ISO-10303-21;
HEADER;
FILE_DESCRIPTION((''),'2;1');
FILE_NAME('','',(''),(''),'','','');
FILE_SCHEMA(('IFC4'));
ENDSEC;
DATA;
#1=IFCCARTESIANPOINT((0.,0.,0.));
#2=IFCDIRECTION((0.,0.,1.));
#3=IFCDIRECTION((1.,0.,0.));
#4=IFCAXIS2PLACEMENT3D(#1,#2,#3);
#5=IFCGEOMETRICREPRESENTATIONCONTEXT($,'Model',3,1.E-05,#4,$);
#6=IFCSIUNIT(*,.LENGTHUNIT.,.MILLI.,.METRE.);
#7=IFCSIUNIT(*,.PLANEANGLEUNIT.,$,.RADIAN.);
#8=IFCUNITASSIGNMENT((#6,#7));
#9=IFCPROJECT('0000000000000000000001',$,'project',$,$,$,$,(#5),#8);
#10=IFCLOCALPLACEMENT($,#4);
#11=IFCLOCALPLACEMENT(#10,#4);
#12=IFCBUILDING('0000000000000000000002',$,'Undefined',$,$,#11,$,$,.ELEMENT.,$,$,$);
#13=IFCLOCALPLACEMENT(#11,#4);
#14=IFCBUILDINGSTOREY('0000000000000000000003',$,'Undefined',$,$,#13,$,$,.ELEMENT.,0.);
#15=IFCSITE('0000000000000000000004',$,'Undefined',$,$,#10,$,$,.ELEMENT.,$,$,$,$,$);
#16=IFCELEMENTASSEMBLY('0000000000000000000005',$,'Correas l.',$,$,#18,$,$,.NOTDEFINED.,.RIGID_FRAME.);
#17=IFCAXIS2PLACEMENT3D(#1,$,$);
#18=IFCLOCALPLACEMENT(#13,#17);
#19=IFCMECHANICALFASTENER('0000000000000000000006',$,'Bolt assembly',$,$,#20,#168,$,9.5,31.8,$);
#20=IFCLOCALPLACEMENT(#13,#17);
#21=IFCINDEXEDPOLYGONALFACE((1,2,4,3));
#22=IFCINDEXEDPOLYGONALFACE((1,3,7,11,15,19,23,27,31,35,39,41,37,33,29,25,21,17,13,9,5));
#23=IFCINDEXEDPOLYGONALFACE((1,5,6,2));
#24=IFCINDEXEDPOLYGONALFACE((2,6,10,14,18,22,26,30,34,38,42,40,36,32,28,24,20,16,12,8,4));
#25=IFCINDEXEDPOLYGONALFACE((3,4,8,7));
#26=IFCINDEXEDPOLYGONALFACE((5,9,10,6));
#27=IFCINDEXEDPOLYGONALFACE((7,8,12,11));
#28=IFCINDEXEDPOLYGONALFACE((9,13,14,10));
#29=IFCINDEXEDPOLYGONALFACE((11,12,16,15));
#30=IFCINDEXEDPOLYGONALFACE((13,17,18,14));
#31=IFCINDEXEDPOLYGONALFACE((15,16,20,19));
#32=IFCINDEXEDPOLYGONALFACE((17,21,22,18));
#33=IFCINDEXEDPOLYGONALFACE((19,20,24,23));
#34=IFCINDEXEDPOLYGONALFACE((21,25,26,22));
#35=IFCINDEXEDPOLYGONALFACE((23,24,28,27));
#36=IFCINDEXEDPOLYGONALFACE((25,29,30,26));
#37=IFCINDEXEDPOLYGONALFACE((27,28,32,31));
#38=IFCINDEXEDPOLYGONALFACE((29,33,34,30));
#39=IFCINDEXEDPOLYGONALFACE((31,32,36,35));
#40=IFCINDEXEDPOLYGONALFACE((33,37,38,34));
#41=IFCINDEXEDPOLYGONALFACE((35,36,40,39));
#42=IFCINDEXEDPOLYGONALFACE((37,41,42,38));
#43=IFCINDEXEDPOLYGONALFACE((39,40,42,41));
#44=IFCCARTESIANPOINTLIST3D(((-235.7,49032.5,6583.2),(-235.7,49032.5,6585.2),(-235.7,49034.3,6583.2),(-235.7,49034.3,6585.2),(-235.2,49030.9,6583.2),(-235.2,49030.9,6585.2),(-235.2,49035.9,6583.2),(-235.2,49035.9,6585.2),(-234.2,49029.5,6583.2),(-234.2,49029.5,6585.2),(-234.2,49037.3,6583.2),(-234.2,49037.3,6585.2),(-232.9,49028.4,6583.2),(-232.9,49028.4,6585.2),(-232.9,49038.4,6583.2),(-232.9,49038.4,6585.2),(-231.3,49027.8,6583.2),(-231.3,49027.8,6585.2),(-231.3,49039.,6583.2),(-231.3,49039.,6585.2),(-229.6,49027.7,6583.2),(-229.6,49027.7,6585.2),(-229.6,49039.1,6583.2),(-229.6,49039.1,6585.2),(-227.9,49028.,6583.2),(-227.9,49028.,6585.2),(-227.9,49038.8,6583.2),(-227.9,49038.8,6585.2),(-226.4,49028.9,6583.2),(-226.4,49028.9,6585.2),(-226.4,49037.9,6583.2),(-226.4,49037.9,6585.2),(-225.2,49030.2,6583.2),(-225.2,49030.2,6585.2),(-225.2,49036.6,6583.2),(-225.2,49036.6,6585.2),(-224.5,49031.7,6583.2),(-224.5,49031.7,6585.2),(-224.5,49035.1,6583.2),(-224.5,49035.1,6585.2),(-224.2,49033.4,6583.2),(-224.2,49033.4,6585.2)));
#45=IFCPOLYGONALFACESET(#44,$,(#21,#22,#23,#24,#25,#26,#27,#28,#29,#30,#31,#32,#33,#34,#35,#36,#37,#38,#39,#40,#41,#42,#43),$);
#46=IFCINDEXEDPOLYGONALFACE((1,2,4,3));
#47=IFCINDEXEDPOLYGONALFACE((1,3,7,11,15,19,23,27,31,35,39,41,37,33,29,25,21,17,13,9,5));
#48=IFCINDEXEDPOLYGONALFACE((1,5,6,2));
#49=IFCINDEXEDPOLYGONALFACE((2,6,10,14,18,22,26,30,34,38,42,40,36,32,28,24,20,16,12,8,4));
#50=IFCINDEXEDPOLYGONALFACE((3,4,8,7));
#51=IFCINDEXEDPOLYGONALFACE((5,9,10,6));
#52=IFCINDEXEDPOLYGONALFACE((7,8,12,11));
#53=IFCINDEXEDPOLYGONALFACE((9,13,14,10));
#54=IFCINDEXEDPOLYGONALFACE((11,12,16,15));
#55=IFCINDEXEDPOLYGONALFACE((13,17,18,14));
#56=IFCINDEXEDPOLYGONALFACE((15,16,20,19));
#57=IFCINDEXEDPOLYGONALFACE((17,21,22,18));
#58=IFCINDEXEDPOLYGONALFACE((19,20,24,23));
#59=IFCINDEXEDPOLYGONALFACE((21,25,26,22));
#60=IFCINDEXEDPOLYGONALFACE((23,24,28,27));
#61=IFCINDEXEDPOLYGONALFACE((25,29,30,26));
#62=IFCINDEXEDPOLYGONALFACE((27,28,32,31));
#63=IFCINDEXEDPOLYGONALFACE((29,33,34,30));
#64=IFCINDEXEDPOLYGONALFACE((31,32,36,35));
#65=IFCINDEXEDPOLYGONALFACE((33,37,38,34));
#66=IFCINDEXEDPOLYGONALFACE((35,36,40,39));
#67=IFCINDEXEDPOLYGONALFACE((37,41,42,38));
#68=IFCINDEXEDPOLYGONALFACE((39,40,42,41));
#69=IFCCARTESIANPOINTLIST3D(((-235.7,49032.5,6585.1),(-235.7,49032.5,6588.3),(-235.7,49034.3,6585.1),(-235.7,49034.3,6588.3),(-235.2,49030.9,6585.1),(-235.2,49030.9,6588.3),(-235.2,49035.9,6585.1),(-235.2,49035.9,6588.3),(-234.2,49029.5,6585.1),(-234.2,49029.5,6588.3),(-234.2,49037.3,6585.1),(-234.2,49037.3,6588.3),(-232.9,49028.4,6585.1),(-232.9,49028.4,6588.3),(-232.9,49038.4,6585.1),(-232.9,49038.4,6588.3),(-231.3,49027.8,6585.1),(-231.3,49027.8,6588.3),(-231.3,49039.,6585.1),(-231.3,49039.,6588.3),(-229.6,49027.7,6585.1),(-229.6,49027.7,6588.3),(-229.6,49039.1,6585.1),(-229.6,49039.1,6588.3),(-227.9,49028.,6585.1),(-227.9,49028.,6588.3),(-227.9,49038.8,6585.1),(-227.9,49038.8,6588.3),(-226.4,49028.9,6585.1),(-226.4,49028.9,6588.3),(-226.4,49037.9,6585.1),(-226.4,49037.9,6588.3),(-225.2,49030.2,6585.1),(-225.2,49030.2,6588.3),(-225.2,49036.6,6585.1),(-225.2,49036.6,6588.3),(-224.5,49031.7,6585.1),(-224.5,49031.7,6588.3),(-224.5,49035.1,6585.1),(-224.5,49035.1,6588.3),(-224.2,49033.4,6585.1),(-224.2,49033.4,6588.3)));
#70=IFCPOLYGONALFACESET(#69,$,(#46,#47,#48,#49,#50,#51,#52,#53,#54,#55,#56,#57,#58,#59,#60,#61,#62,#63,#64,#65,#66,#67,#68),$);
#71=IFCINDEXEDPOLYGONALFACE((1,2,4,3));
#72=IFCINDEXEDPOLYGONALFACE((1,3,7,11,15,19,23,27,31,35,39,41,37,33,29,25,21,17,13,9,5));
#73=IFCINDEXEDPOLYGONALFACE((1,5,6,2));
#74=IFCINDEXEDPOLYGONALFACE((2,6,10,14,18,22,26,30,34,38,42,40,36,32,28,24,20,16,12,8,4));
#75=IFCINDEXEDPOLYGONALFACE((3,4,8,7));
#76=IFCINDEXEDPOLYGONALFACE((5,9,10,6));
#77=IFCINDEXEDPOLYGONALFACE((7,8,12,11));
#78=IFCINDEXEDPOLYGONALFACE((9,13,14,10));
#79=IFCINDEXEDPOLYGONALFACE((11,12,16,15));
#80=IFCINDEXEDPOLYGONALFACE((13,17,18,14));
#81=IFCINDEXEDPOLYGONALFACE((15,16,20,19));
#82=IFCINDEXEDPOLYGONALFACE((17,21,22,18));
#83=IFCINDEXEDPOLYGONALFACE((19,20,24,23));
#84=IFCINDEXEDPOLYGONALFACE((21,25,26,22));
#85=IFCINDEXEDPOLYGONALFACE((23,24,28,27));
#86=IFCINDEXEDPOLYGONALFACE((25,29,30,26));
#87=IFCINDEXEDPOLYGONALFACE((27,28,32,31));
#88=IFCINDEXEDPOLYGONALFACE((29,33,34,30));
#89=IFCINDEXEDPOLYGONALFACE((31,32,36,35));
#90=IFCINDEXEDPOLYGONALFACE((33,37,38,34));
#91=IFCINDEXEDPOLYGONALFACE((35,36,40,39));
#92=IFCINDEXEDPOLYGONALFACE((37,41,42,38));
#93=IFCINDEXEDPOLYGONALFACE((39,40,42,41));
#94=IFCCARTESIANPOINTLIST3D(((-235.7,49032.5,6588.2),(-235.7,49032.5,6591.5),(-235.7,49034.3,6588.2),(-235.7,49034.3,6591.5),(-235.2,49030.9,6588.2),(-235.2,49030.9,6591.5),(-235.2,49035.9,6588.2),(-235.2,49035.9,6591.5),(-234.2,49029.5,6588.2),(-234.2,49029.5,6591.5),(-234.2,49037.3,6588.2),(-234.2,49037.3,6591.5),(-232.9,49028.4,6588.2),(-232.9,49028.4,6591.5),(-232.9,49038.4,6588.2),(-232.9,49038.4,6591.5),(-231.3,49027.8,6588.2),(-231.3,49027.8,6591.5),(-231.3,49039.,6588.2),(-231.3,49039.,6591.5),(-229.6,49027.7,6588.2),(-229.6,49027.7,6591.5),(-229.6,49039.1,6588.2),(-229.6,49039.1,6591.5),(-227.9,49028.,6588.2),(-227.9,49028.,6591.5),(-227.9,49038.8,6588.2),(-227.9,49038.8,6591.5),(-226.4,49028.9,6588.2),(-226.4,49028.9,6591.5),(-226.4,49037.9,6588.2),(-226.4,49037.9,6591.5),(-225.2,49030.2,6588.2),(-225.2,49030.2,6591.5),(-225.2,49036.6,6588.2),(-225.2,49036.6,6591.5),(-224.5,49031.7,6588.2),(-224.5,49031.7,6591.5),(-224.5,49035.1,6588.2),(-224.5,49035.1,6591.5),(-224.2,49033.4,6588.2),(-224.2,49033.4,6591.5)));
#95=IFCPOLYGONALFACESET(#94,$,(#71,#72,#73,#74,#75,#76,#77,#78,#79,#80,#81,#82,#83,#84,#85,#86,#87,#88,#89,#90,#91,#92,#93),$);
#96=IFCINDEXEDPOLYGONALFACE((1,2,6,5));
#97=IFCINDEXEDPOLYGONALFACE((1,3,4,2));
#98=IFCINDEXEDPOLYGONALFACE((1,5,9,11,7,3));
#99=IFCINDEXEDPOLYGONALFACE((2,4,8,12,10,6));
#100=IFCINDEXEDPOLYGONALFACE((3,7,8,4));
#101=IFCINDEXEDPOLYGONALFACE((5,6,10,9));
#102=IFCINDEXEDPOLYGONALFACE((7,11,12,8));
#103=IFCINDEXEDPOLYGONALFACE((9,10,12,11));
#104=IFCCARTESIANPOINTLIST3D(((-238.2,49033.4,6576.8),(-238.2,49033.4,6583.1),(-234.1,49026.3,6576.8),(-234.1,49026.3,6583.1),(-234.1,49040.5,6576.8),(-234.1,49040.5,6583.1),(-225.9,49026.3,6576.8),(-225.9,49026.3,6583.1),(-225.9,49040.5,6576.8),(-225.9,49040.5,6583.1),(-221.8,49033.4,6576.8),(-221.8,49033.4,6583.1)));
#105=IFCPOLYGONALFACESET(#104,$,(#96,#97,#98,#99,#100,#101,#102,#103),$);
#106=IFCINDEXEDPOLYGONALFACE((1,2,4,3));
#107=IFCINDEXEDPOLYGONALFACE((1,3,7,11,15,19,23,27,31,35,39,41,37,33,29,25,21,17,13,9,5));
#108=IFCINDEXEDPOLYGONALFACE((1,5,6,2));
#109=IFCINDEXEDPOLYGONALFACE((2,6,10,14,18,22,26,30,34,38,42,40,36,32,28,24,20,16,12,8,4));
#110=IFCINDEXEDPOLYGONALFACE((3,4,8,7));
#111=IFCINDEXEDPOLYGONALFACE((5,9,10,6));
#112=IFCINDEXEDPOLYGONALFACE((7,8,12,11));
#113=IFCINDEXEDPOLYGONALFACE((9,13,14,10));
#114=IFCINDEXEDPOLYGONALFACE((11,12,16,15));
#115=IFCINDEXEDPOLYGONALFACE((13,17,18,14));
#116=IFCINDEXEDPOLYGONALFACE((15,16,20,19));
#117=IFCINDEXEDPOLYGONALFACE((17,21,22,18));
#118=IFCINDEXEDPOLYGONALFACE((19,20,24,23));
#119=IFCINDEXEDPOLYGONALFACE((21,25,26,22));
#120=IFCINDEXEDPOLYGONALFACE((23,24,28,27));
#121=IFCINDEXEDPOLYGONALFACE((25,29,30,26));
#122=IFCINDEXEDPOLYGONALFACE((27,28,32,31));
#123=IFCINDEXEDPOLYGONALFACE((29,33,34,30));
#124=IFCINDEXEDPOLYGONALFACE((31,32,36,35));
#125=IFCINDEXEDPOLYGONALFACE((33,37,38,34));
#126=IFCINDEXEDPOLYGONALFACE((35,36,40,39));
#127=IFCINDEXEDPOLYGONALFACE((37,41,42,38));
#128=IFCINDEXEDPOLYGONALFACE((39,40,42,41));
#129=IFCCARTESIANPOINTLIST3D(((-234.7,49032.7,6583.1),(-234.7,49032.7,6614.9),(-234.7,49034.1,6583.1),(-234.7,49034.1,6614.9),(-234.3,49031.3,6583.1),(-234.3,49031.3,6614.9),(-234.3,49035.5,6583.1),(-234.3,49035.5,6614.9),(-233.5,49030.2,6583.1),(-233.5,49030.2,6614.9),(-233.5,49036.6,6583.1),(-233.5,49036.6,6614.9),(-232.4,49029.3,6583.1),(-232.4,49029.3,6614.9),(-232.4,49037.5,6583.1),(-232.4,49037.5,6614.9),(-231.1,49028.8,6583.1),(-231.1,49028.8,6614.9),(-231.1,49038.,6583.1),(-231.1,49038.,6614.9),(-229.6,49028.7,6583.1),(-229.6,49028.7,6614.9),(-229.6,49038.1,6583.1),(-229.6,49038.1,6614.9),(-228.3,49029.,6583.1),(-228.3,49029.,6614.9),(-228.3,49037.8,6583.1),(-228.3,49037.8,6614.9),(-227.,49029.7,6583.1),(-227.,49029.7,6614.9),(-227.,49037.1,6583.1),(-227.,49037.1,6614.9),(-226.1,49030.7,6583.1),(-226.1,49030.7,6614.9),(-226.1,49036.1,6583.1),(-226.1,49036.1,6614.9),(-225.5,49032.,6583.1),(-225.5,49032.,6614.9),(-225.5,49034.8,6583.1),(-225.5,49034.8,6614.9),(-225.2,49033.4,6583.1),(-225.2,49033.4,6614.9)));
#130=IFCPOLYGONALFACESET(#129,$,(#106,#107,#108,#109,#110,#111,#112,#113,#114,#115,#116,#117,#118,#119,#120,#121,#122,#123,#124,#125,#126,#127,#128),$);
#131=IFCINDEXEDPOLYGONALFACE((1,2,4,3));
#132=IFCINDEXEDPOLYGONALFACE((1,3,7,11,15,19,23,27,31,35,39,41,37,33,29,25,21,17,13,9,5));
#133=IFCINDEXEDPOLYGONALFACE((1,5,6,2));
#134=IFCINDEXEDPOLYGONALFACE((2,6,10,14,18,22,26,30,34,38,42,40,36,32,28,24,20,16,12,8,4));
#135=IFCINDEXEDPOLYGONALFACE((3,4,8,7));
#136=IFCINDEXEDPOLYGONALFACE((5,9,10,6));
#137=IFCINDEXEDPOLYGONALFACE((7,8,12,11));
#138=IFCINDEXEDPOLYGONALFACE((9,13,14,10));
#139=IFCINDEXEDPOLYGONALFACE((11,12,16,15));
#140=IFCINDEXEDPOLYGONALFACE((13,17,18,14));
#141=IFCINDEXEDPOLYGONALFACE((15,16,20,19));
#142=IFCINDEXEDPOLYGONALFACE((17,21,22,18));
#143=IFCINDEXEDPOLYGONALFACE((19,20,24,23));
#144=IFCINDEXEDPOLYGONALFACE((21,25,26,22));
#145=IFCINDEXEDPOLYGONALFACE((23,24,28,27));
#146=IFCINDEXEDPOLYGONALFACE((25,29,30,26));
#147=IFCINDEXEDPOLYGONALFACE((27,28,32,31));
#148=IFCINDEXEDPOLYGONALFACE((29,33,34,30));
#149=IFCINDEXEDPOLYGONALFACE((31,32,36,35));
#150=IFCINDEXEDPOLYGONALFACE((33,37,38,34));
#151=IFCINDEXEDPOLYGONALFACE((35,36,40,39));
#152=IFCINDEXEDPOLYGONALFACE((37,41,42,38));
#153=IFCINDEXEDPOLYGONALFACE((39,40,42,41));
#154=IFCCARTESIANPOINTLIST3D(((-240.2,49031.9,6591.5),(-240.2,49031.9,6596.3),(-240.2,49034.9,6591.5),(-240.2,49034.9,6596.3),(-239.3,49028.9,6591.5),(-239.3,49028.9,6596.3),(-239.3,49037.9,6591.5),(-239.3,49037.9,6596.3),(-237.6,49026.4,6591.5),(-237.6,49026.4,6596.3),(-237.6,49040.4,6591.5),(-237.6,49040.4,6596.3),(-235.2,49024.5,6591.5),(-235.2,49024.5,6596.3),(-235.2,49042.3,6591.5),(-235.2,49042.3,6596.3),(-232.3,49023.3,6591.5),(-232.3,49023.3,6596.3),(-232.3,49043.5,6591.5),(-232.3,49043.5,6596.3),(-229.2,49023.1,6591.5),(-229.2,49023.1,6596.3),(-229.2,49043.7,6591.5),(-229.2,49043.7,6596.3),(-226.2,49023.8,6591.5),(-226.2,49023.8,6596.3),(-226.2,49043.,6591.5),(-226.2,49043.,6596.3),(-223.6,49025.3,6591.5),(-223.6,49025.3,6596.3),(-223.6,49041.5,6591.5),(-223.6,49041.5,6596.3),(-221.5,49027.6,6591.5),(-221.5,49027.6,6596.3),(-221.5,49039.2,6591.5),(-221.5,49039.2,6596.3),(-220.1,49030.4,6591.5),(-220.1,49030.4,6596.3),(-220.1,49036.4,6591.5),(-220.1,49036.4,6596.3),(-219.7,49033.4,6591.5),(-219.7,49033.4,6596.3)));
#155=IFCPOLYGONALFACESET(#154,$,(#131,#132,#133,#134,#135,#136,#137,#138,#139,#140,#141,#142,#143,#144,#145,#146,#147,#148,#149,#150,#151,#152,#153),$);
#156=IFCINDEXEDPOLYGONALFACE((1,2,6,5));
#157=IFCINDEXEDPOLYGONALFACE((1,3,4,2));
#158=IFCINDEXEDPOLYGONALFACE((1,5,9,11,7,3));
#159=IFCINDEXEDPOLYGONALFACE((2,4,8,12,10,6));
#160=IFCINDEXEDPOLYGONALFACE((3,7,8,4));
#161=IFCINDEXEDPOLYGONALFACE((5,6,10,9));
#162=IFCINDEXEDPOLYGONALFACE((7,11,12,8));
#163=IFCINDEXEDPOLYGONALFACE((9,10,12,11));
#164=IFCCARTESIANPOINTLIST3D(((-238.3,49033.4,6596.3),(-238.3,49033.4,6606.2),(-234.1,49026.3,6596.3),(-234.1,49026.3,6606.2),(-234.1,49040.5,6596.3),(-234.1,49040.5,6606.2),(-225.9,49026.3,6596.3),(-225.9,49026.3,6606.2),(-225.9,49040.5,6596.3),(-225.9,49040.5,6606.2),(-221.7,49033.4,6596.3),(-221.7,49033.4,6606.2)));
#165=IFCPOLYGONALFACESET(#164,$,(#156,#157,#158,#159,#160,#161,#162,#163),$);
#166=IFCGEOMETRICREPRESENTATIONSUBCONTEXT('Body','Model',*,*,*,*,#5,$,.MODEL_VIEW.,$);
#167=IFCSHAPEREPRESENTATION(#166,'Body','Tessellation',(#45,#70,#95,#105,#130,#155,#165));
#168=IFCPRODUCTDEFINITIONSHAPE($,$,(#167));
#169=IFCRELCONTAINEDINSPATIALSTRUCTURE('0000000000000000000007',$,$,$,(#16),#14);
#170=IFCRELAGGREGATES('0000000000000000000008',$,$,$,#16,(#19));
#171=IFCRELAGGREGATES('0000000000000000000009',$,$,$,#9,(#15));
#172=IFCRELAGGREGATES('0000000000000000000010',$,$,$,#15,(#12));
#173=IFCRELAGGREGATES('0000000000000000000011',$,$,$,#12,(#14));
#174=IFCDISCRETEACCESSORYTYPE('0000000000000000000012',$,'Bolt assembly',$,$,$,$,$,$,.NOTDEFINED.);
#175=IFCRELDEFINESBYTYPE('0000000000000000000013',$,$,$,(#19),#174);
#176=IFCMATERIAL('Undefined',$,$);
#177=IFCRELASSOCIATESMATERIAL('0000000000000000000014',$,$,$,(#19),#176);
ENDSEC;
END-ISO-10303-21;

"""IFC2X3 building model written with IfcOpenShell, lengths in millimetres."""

from ifc_helpers import new_model, si_unit, frame, origin_with_axes, origin_2d_with_axis, place, context, subcontext, project, spatial, polyline, circle, outline, extrude, source, transform, mapped, material, type_object, element, aggregate, save


model = new_model("IFC2X3")

# Units and contexts
model_context = context("Model", 3, precision=1e-05, world=origin_with_axes())
body_context = subcontext(model_context, "Body", "Model", "MODEL_VIEW")
ifc_project = project(units=[si_unit("LENGTHUNIT", "METRE", prefix="MILLI"), si_unit("PLANEANGLEUNIT", "RADIAN")], contexts=[model_context])

# Site, building, storey
site_placement = place(None, origin_with_axes())
site = spatial("IfcSite", under=ifc_project, at=site_placement, Name="Undefined", CompositionType="ELEMENT")
building_placement = place(site_placement, origin_with_axes())
building = spatial("IfcBuilding", under=site, at=building_placement, Name="Undefined", CompositionType="ELEMENT")
storey_placement = place(building_placement, origin_with_axes())
storey = spatial("IfcBuildingStorey", under=building, at=storey_placement, Name="Undefined", CompositionType="ELEMENT", Elevation=0.0)

# Element assembly
assembly_1_placement = place(storey_placement, origin_with_axes())
assembly_1 = element("IfcElementAssembly", 1, at=assembly_1_placement, inside=storey, Name="Correas l.", AssemblyPlace="NOTDEFINED", PredefinedType="RIGID_FRAME")

# Shared definitions
discrete_accessory_type_1 = type_object("IfcDiscreteAccessoryType", Name="Bolt assembly")

# Mechanical fastener
ifc_material_1 = material(Name="Undefined")
shared_shape_1 = source(origin_with_axes(), body_context, "Body", "SweptSolid", [
    extrude(circle(Radius=5.8, at=origin_2d_with_axis()), frame((0.0, -5.1, 0.0), z_axis=(0.0, 1.0, 0.0), x_axis=(1.0, 0.0, 0.0)), (0.0, 0.0, 1.0), 2.0),
    extrude(circle(Radius=5.8, at=origin_2d_with_axis()), frame((0.0, -3.2, 0.0), z_axis=(0.0, 1.0, 0.0), x_axis=(1.0, 0.0, 0.0)), (0.0, 0.0, 1.0), 3.2),
    extrude(circle(Radius=5.8, at=origin_2d_with_axis()), frame((0.0, -0.1, 0.0), z_axis=(0.0, 1.0, 0.0), x_axis=(1.0, 0.0, 0.0)), (0.0, 0.0, 1.0), 3.3),
    extrude(outline(polyline([(8.2, 0.0), (4.1, 7.1), (-4.1, 7.1), (-8.2, 0.0), (-4.1, -7.1), (4.1, -7.1), (8.2, 0.0)])), frame((0.0, -11.5, 0.0), z_axis=(0.0, 1.0, 0.0), x_axis=(1.0, 0.0, 0.0)), (0.0, 0.0, 1.0), 6.3),
    extrude(circle(Radius=4.8, at=origin_2d_with_axis()), frame((0.0, -5.2, 0.0), z_axis=(0.0, 1.0, 0.0), x_axis=(1.0, 0.0, 0.0)), (0.0, 0.0, 1.0), 31.8),
    extrude(circle(Radius=10.3, at=origin_2d_with_axis()), frame((0.0, 3.2, 0.0), z_axis=(0.0, 1.0, 0.0), x_axis=(1.0, 0.0, 0.0)), (0.0, 0.0, 1.0), 4.8),
    extrude(outline(polyline([(8.3, 0.0), (4.1, 7.1), (-4.1, 7.1), (-8.3, 0.0), (-4.1, -7.1), (4.1, -7.1), (8.3, 0.0)])), frame((0.0, 8.0, 0.0), z_axis=(0.0, 1.0, 0.0), x_axis=(1.0, 0.0, 0.0)), (0.0, 0.0, 1.0), 9.9),
])
mechanical_fastener_1_placement = place(assembly_1_placement, frame((-230.0, 49033.4, 6588.3), z_axis=(0.0, -1.0, 0.0), x_axis=(1.0, 0.0, 0.0)))
mechanical_fastener_1 = element("IfcMechanicalFastener", 2, at=mechanical_fastener_1_placement, type_object=discrete_accessory_type_1, material=ifc_material_1, Name="Bolt assembly", NominalDiameter=9.5, NominalLength=31.8, context=body_context, shape_type="MappedRepresentation", body=[
    mapped(shared_shape_1, transform((0.0, 0.0, 0.0))),
])
aggregate(assembly_1, [mechanical_fastener_1])

save(model, "model.ifc")
